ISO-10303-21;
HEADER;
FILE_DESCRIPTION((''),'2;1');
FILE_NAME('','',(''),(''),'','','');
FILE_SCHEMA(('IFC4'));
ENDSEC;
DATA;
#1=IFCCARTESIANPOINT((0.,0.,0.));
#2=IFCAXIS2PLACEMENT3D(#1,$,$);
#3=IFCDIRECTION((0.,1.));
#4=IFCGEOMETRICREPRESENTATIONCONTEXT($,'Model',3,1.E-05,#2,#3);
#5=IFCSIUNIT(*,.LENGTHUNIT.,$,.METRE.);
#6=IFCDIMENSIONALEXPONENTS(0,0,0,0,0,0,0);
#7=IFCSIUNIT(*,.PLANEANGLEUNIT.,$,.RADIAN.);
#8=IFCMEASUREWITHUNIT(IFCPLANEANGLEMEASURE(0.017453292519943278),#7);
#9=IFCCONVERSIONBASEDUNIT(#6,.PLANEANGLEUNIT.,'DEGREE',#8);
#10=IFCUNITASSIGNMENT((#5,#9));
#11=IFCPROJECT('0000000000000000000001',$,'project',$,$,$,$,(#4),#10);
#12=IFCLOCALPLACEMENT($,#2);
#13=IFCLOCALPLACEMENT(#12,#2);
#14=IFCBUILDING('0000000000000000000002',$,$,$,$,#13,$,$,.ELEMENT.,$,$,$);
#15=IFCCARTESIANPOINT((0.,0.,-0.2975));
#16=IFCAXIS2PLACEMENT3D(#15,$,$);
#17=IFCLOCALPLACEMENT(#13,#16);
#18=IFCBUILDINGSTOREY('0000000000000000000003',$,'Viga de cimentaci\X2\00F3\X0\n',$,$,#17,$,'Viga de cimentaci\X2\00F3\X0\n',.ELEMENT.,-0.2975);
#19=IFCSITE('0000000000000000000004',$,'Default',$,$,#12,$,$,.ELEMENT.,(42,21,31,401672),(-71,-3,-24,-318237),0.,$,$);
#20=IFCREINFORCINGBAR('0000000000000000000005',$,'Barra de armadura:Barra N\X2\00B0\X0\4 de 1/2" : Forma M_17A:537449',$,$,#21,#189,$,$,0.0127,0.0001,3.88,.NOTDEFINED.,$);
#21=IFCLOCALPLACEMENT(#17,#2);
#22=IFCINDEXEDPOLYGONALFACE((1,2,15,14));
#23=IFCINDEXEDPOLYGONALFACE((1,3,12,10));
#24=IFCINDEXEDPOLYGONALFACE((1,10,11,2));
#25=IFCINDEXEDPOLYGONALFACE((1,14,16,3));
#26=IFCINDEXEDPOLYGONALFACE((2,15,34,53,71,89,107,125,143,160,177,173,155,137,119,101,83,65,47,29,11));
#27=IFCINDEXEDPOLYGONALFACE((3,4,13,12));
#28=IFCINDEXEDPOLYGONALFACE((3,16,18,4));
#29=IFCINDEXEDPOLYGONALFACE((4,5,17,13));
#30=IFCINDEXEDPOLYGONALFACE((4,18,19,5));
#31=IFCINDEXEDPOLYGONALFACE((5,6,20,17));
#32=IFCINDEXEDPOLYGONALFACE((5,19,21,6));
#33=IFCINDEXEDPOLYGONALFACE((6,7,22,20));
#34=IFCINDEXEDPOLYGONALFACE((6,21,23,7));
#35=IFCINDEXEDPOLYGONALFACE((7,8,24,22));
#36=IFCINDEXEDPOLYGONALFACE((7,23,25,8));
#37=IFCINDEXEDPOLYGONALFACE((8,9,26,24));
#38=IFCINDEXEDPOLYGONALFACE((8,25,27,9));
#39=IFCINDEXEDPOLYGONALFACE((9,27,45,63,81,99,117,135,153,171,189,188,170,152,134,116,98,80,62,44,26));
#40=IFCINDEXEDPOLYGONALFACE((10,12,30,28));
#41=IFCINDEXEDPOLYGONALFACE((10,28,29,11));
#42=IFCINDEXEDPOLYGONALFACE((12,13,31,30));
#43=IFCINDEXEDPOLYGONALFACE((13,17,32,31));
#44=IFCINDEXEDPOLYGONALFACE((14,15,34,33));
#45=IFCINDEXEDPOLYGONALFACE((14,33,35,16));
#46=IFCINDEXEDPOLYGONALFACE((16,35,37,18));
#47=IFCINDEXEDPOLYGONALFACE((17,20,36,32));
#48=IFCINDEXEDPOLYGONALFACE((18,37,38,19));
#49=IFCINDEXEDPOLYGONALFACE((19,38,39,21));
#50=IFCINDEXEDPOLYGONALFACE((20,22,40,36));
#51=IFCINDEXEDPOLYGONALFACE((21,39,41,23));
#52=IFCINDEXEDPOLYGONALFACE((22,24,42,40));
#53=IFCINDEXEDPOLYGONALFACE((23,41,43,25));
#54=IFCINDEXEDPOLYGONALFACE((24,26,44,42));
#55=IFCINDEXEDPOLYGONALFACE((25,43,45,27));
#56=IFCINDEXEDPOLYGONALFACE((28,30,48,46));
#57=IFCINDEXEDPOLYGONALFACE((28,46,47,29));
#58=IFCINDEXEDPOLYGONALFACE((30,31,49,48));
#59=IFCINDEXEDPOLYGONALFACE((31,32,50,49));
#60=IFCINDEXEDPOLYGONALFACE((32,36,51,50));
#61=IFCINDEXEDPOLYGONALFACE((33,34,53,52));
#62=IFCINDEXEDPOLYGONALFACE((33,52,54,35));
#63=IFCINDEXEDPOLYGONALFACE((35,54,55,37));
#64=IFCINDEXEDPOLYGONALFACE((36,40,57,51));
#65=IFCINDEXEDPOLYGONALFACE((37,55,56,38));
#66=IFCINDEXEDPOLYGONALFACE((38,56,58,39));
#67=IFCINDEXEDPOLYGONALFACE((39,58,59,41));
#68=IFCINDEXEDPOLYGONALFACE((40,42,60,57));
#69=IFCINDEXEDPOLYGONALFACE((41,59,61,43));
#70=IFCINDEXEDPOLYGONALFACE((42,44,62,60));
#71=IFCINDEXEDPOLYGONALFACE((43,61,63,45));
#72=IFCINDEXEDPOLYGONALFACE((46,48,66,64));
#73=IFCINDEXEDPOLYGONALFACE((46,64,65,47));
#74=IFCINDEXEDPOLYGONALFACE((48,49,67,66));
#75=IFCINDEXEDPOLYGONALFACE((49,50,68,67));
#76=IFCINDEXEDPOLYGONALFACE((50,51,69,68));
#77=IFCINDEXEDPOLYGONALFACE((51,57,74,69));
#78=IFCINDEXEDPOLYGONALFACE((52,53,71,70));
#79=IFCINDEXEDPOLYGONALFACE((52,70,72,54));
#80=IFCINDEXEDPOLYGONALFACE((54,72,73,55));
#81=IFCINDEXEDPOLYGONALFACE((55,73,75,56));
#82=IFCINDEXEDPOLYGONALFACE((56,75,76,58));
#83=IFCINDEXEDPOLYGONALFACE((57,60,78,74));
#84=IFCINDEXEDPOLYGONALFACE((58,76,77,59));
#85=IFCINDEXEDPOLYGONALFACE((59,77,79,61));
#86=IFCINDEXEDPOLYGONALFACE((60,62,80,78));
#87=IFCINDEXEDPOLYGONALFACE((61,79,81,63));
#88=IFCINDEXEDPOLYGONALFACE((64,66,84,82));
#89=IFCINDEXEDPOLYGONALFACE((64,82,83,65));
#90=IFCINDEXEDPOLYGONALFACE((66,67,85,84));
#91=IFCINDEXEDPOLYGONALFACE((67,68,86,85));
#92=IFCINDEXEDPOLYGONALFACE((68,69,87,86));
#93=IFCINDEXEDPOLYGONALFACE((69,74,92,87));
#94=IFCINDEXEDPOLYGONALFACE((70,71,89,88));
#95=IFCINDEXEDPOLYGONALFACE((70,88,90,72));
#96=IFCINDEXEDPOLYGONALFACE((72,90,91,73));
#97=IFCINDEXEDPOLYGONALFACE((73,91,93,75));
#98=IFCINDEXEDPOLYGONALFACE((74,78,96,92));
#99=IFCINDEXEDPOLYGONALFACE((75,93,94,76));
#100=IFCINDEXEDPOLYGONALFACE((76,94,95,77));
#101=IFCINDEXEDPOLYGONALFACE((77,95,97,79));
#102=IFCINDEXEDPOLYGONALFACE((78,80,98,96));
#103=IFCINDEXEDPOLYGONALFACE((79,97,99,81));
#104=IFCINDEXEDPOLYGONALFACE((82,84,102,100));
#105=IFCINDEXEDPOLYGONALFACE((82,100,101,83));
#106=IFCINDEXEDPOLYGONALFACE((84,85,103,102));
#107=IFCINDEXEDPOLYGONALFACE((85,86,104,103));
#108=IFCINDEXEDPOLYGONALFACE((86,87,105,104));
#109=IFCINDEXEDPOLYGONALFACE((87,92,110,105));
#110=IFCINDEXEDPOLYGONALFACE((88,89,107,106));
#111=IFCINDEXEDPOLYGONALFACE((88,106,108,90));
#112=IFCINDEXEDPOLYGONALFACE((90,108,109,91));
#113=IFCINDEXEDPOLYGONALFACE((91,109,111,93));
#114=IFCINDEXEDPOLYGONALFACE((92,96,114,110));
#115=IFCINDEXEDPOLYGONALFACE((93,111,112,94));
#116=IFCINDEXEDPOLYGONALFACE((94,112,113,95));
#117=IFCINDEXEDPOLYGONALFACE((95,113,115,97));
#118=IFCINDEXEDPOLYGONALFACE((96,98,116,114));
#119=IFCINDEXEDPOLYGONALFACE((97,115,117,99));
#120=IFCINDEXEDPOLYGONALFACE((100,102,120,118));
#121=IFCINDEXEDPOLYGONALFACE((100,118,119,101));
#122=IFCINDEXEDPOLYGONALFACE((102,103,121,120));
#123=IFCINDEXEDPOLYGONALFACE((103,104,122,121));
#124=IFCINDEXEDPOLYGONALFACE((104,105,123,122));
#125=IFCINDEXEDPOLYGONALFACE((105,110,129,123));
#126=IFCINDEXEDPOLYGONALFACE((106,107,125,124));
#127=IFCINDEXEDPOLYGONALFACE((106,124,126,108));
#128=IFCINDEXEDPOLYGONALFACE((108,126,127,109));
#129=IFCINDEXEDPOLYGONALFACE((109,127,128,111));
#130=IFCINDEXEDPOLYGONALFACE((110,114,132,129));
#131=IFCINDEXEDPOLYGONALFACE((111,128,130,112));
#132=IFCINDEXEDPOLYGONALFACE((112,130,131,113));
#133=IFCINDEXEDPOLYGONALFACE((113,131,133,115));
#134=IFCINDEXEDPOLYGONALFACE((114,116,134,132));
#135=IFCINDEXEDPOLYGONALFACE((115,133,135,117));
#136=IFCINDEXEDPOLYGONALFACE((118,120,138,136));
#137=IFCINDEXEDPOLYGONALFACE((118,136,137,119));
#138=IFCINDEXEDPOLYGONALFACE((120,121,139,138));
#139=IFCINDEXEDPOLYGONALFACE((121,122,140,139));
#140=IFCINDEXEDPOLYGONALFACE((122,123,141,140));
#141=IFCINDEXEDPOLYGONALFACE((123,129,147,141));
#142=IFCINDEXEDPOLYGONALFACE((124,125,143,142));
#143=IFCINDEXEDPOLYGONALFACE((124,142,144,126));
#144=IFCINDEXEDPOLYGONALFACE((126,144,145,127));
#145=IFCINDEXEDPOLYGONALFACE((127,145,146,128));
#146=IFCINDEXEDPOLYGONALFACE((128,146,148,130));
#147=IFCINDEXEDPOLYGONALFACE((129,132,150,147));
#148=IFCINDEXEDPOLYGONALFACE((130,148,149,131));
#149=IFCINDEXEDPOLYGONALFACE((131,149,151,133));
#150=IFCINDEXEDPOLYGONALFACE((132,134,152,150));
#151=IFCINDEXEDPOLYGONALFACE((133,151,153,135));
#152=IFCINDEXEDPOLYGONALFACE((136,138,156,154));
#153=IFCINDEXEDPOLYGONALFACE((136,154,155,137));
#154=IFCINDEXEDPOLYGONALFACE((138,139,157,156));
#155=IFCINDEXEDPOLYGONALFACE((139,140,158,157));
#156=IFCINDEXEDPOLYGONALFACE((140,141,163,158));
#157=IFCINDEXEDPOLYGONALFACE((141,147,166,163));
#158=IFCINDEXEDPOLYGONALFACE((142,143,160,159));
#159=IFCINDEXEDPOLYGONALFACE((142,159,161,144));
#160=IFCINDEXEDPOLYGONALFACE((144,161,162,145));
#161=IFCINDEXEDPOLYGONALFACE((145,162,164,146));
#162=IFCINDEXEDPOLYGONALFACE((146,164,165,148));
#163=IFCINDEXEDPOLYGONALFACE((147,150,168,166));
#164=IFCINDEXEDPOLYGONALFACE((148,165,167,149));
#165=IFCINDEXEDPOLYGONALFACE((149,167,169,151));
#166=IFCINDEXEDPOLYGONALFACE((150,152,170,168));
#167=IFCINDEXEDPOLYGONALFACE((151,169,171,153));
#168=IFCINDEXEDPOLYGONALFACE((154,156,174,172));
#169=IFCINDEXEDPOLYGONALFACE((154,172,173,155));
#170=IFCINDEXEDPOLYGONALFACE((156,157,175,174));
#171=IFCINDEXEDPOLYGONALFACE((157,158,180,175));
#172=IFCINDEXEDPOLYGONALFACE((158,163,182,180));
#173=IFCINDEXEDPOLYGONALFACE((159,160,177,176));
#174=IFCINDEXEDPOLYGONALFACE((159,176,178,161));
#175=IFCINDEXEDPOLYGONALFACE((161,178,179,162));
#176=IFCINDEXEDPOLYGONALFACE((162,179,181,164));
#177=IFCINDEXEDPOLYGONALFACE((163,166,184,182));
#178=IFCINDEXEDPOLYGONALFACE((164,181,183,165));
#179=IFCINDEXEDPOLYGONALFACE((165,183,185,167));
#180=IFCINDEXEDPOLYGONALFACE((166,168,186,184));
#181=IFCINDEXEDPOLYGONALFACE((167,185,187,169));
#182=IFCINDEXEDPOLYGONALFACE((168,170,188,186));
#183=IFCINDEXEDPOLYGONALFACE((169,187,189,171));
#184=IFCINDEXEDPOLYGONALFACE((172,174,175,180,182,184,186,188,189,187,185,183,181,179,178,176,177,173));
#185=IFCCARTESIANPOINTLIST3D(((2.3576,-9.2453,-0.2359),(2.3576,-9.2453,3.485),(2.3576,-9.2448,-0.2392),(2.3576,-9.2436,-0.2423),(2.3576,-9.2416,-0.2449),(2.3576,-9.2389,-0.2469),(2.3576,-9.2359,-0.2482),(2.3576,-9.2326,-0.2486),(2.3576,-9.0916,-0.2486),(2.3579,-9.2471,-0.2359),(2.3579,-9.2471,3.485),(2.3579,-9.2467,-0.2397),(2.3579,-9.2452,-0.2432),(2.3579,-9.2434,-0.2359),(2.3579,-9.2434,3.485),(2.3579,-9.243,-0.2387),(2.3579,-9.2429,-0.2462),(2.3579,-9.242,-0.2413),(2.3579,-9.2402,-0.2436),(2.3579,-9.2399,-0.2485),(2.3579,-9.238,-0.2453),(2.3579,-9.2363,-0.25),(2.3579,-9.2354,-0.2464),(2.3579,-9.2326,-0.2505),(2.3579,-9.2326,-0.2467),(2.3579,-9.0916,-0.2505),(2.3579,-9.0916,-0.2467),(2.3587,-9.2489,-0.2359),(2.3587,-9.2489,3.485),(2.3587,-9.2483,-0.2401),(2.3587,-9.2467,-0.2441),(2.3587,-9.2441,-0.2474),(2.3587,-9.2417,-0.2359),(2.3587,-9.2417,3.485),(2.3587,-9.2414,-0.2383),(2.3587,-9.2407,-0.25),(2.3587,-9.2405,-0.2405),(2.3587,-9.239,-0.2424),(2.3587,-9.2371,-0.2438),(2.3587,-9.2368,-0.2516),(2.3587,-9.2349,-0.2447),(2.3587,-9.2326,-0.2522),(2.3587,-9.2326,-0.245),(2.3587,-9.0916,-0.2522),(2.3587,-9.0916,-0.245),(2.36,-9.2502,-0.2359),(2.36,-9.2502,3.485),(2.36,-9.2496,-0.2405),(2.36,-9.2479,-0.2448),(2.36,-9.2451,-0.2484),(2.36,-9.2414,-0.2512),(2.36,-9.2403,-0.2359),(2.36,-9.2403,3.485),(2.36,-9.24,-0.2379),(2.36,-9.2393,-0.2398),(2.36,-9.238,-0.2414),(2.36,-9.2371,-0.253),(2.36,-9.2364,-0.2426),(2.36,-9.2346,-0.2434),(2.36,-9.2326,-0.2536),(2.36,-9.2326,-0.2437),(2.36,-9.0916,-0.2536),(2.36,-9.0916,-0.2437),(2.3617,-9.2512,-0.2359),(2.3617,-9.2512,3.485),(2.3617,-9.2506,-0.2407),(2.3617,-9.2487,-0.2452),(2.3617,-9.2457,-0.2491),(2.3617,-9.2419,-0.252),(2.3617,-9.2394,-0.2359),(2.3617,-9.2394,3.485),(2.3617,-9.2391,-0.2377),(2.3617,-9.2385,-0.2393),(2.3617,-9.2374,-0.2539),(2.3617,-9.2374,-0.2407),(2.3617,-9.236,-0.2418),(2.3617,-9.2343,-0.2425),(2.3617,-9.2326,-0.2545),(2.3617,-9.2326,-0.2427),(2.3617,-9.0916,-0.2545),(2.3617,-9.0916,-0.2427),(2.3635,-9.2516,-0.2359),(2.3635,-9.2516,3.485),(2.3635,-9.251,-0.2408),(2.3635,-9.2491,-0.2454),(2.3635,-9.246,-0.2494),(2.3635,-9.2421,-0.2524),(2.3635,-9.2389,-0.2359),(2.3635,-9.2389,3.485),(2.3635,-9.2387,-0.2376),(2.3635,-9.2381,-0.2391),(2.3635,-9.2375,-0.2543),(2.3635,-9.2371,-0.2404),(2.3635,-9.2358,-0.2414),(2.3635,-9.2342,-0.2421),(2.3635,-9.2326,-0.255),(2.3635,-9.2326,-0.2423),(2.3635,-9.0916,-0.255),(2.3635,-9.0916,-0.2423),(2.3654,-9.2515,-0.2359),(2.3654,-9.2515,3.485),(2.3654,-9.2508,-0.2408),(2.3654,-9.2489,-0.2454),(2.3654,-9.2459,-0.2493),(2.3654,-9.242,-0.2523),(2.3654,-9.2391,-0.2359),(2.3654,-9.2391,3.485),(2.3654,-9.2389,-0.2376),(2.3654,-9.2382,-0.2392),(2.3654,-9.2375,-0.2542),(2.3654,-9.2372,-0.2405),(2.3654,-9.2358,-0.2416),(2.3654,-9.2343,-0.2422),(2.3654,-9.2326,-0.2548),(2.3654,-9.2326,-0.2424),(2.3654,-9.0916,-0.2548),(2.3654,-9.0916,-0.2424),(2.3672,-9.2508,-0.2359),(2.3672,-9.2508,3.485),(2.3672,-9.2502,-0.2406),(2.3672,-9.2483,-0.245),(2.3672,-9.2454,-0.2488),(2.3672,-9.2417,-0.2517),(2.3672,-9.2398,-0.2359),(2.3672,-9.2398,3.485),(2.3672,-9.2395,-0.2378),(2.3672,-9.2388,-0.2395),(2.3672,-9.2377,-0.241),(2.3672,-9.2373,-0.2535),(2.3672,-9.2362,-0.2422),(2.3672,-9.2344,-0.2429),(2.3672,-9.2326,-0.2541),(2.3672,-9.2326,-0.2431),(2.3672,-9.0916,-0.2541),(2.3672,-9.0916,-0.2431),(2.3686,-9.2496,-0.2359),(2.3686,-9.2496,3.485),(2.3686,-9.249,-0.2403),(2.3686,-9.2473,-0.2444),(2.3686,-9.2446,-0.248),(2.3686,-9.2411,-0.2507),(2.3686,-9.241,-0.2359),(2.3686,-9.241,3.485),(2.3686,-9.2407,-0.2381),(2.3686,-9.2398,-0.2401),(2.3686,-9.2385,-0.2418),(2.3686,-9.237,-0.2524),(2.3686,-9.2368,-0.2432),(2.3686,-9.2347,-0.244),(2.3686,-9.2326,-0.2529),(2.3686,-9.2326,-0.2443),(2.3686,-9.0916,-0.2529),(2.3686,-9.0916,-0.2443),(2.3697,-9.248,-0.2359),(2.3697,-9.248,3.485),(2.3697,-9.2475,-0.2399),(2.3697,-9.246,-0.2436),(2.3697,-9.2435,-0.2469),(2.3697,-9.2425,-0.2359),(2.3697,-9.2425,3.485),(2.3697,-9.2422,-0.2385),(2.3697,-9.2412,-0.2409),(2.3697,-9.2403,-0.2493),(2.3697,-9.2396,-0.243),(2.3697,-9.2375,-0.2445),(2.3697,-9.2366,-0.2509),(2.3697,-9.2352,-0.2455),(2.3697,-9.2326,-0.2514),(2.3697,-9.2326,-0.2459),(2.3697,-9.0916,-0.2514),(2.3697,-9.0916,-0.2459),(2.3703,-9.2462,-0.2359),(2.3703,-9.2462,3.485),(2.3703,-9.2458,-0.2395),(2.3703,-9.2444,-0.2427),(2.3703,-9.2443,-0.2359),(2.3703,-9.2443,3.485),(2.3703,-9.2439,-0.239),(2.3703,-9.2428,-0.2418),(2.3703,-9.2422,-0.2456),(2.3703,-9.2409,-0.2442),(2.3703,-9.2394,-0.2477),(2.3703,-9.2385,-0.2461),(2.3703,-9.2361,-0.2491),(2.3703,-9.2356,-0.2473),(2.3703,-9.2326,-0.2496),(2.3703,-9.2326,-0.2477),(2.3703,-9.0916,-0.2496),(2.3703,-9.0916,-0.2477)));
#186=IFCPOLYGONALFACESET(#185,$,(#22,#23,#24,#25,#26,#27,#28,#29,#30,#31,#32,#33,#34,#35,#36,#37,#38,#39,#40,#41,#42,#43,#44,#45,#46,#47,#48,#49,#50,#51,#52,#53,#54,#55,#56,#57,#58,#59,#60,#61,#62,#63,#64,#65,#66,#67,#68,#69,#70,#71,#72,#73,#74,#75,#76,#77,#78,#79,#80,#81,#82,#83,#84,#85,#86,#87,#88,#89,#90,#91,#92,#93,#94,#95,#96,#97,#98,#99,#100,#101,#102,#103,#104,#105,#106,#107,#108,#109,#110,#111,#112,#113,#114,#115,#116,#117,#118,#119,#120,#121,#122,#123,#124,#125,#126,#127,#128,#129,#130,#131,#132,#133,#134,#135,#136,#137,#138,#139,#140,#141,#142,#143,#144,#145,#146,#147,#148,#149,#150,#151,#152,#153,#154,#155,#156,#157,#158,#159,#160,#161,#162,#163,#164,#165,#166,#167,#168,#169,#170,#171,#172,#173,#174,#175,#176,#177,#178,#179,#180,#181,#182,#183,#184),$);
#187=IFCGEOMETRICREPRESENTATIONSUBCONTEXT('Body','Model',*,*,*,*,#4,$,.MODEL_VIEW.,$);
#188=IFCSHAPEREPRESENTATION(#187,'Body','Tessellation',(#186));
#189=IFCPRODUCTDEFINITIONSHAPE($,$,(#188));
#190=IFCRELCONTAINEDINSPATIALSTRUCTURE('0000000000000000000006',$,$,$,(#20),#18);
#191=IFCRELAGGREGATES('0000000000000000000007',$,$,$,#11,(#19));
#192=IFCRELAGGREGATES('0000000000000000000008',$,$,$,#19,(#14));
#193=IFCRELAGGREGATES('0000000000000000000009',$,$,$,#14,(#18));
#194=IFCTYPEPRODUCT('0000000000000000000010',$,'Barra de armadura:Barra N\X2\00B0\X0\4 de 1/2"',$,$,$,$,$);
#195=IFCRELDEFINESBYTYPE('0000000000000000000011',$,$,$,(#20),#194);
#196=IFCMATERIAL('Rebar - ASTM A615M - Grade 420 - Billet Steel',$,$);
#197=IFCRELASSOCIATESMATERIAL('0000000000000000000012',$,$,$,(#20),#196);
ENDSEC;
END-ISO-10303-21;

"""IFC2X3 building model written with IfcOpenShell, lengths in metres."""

from ifc_helpers import new_model, entity, si_unit, converted_unit, direction, frame, origin, place, context, subcontext, project, spatial, material, type_object, element, save


model = new_model("IFC2X3")

# Units and contexts
model_context = context("Model", 3, precision=1e-05, world=origin(), true_north=direction((0.0, 1.0)))
body_context = subcontext(model_context, "Body", "Model", "MODEL_VIEW")
ifc_project = project(units=[si_unit("LENGTHUNIT", "METRE"), converted_unit("PLANEANGLEUNIT", "DEGREE", entity("IfcPlaneAngleMeasure", 0.017453292519943278), si_unit("PLANEANGLEUNIT", "RADIAN"), dimensions=[0, 0, 0, 0, 0, 0, 0])], contexts=[model_context])

# Site, building, storey
site_placement = place(None, origin())
site = spatial("IfcSite", under=ifc_project, at=site_placement, Name="Default", CompositionType="ELEMENT", RefLatitude=(42, 21, 31, 401672), RefLongitude=(-71, -3, -24, -318237), RefElevation=0.0)
building_placement = place(site_placement, origin())
building = spatial("IfcBuilding", under=site, at=building_placement, CompositionType="ELEMENT")
storey_placement = place(building_placement, frame((0.0, 0.0, -0.2975)))
storey = spatial("IfcBuildingStorey", under=building, at=storey_placement, Name="Viga de cimentación", LongName="Viga de cimentación", CompositionType="ELEMENT", Elevation=-0.2975)

# Reinforcing bar
ifc_material = material(Name="Rebar - ASTM A615M - Grade 420 - Billet Steel")
type_product_1 = type_object("IfcTypeProduct", Name="Barra de armadura:Barra N°4 de 1/2\"")
reinforcing_bar_1_placement = place(storey_placement, origin())
element("IfcReinforcingBar", 1, at=reinforcing_bar_1_placement, inside=storey, type_object=type_product_1, material=ifc_material, Name="Barra de armadura:Barra N°4 de 1/2\" : Forma M_17A:537449", BarLength=3.88, BarRole="NOTDEFINED", CrossSectionArea=0.0001, NominalDiameter=0.0127, context=body_context, shape_type="AdvancedSweptSolid", body=[
    entity("IfcSweptDiskSolid", entity("IfcCompositeCurve", [entity("IfcCompositeCurveSegment", "CONTINUOUS", True, entity("IfcPolyline", [entity("IfcCartesianPoint", [2.364, -9.2453, 3.485]), entity("IfcCartesianPoint", [2.364, -9.2453, -0.2359])])), entity("IfcCompositeCurveSegment", "CONTINUOUS", True, entity("IfcTrimmedCurve", entity("IfcCircle", entity("IfcAxis2Placement3D", entity("IfcCartesianPoint", [2.364, -9.2326, -0.2359]), entity("IfcDirection", [1.0, 0.0, 0.0]), entity("IfcDirection", [0.0, 0.0, -1.0])), 0.0127), [entity("IfcParameterValue", 270.0)], [entity("IfcParameterValue", 360.0)], True, "PARAMETER")), entity("IfcCompositeCurveSegment", "CONTINUOUS", True, entity("IfcPolyline", [entity("IfcCartesianPoint", [2.364, -9.2326, -0.2486]), entity("IfcCartesianPoint", [2.364, -9.0916, -0.2486])]))], False), 0.0063, None, 0.0, 92.0),
])

save(model, "model.ifc")
